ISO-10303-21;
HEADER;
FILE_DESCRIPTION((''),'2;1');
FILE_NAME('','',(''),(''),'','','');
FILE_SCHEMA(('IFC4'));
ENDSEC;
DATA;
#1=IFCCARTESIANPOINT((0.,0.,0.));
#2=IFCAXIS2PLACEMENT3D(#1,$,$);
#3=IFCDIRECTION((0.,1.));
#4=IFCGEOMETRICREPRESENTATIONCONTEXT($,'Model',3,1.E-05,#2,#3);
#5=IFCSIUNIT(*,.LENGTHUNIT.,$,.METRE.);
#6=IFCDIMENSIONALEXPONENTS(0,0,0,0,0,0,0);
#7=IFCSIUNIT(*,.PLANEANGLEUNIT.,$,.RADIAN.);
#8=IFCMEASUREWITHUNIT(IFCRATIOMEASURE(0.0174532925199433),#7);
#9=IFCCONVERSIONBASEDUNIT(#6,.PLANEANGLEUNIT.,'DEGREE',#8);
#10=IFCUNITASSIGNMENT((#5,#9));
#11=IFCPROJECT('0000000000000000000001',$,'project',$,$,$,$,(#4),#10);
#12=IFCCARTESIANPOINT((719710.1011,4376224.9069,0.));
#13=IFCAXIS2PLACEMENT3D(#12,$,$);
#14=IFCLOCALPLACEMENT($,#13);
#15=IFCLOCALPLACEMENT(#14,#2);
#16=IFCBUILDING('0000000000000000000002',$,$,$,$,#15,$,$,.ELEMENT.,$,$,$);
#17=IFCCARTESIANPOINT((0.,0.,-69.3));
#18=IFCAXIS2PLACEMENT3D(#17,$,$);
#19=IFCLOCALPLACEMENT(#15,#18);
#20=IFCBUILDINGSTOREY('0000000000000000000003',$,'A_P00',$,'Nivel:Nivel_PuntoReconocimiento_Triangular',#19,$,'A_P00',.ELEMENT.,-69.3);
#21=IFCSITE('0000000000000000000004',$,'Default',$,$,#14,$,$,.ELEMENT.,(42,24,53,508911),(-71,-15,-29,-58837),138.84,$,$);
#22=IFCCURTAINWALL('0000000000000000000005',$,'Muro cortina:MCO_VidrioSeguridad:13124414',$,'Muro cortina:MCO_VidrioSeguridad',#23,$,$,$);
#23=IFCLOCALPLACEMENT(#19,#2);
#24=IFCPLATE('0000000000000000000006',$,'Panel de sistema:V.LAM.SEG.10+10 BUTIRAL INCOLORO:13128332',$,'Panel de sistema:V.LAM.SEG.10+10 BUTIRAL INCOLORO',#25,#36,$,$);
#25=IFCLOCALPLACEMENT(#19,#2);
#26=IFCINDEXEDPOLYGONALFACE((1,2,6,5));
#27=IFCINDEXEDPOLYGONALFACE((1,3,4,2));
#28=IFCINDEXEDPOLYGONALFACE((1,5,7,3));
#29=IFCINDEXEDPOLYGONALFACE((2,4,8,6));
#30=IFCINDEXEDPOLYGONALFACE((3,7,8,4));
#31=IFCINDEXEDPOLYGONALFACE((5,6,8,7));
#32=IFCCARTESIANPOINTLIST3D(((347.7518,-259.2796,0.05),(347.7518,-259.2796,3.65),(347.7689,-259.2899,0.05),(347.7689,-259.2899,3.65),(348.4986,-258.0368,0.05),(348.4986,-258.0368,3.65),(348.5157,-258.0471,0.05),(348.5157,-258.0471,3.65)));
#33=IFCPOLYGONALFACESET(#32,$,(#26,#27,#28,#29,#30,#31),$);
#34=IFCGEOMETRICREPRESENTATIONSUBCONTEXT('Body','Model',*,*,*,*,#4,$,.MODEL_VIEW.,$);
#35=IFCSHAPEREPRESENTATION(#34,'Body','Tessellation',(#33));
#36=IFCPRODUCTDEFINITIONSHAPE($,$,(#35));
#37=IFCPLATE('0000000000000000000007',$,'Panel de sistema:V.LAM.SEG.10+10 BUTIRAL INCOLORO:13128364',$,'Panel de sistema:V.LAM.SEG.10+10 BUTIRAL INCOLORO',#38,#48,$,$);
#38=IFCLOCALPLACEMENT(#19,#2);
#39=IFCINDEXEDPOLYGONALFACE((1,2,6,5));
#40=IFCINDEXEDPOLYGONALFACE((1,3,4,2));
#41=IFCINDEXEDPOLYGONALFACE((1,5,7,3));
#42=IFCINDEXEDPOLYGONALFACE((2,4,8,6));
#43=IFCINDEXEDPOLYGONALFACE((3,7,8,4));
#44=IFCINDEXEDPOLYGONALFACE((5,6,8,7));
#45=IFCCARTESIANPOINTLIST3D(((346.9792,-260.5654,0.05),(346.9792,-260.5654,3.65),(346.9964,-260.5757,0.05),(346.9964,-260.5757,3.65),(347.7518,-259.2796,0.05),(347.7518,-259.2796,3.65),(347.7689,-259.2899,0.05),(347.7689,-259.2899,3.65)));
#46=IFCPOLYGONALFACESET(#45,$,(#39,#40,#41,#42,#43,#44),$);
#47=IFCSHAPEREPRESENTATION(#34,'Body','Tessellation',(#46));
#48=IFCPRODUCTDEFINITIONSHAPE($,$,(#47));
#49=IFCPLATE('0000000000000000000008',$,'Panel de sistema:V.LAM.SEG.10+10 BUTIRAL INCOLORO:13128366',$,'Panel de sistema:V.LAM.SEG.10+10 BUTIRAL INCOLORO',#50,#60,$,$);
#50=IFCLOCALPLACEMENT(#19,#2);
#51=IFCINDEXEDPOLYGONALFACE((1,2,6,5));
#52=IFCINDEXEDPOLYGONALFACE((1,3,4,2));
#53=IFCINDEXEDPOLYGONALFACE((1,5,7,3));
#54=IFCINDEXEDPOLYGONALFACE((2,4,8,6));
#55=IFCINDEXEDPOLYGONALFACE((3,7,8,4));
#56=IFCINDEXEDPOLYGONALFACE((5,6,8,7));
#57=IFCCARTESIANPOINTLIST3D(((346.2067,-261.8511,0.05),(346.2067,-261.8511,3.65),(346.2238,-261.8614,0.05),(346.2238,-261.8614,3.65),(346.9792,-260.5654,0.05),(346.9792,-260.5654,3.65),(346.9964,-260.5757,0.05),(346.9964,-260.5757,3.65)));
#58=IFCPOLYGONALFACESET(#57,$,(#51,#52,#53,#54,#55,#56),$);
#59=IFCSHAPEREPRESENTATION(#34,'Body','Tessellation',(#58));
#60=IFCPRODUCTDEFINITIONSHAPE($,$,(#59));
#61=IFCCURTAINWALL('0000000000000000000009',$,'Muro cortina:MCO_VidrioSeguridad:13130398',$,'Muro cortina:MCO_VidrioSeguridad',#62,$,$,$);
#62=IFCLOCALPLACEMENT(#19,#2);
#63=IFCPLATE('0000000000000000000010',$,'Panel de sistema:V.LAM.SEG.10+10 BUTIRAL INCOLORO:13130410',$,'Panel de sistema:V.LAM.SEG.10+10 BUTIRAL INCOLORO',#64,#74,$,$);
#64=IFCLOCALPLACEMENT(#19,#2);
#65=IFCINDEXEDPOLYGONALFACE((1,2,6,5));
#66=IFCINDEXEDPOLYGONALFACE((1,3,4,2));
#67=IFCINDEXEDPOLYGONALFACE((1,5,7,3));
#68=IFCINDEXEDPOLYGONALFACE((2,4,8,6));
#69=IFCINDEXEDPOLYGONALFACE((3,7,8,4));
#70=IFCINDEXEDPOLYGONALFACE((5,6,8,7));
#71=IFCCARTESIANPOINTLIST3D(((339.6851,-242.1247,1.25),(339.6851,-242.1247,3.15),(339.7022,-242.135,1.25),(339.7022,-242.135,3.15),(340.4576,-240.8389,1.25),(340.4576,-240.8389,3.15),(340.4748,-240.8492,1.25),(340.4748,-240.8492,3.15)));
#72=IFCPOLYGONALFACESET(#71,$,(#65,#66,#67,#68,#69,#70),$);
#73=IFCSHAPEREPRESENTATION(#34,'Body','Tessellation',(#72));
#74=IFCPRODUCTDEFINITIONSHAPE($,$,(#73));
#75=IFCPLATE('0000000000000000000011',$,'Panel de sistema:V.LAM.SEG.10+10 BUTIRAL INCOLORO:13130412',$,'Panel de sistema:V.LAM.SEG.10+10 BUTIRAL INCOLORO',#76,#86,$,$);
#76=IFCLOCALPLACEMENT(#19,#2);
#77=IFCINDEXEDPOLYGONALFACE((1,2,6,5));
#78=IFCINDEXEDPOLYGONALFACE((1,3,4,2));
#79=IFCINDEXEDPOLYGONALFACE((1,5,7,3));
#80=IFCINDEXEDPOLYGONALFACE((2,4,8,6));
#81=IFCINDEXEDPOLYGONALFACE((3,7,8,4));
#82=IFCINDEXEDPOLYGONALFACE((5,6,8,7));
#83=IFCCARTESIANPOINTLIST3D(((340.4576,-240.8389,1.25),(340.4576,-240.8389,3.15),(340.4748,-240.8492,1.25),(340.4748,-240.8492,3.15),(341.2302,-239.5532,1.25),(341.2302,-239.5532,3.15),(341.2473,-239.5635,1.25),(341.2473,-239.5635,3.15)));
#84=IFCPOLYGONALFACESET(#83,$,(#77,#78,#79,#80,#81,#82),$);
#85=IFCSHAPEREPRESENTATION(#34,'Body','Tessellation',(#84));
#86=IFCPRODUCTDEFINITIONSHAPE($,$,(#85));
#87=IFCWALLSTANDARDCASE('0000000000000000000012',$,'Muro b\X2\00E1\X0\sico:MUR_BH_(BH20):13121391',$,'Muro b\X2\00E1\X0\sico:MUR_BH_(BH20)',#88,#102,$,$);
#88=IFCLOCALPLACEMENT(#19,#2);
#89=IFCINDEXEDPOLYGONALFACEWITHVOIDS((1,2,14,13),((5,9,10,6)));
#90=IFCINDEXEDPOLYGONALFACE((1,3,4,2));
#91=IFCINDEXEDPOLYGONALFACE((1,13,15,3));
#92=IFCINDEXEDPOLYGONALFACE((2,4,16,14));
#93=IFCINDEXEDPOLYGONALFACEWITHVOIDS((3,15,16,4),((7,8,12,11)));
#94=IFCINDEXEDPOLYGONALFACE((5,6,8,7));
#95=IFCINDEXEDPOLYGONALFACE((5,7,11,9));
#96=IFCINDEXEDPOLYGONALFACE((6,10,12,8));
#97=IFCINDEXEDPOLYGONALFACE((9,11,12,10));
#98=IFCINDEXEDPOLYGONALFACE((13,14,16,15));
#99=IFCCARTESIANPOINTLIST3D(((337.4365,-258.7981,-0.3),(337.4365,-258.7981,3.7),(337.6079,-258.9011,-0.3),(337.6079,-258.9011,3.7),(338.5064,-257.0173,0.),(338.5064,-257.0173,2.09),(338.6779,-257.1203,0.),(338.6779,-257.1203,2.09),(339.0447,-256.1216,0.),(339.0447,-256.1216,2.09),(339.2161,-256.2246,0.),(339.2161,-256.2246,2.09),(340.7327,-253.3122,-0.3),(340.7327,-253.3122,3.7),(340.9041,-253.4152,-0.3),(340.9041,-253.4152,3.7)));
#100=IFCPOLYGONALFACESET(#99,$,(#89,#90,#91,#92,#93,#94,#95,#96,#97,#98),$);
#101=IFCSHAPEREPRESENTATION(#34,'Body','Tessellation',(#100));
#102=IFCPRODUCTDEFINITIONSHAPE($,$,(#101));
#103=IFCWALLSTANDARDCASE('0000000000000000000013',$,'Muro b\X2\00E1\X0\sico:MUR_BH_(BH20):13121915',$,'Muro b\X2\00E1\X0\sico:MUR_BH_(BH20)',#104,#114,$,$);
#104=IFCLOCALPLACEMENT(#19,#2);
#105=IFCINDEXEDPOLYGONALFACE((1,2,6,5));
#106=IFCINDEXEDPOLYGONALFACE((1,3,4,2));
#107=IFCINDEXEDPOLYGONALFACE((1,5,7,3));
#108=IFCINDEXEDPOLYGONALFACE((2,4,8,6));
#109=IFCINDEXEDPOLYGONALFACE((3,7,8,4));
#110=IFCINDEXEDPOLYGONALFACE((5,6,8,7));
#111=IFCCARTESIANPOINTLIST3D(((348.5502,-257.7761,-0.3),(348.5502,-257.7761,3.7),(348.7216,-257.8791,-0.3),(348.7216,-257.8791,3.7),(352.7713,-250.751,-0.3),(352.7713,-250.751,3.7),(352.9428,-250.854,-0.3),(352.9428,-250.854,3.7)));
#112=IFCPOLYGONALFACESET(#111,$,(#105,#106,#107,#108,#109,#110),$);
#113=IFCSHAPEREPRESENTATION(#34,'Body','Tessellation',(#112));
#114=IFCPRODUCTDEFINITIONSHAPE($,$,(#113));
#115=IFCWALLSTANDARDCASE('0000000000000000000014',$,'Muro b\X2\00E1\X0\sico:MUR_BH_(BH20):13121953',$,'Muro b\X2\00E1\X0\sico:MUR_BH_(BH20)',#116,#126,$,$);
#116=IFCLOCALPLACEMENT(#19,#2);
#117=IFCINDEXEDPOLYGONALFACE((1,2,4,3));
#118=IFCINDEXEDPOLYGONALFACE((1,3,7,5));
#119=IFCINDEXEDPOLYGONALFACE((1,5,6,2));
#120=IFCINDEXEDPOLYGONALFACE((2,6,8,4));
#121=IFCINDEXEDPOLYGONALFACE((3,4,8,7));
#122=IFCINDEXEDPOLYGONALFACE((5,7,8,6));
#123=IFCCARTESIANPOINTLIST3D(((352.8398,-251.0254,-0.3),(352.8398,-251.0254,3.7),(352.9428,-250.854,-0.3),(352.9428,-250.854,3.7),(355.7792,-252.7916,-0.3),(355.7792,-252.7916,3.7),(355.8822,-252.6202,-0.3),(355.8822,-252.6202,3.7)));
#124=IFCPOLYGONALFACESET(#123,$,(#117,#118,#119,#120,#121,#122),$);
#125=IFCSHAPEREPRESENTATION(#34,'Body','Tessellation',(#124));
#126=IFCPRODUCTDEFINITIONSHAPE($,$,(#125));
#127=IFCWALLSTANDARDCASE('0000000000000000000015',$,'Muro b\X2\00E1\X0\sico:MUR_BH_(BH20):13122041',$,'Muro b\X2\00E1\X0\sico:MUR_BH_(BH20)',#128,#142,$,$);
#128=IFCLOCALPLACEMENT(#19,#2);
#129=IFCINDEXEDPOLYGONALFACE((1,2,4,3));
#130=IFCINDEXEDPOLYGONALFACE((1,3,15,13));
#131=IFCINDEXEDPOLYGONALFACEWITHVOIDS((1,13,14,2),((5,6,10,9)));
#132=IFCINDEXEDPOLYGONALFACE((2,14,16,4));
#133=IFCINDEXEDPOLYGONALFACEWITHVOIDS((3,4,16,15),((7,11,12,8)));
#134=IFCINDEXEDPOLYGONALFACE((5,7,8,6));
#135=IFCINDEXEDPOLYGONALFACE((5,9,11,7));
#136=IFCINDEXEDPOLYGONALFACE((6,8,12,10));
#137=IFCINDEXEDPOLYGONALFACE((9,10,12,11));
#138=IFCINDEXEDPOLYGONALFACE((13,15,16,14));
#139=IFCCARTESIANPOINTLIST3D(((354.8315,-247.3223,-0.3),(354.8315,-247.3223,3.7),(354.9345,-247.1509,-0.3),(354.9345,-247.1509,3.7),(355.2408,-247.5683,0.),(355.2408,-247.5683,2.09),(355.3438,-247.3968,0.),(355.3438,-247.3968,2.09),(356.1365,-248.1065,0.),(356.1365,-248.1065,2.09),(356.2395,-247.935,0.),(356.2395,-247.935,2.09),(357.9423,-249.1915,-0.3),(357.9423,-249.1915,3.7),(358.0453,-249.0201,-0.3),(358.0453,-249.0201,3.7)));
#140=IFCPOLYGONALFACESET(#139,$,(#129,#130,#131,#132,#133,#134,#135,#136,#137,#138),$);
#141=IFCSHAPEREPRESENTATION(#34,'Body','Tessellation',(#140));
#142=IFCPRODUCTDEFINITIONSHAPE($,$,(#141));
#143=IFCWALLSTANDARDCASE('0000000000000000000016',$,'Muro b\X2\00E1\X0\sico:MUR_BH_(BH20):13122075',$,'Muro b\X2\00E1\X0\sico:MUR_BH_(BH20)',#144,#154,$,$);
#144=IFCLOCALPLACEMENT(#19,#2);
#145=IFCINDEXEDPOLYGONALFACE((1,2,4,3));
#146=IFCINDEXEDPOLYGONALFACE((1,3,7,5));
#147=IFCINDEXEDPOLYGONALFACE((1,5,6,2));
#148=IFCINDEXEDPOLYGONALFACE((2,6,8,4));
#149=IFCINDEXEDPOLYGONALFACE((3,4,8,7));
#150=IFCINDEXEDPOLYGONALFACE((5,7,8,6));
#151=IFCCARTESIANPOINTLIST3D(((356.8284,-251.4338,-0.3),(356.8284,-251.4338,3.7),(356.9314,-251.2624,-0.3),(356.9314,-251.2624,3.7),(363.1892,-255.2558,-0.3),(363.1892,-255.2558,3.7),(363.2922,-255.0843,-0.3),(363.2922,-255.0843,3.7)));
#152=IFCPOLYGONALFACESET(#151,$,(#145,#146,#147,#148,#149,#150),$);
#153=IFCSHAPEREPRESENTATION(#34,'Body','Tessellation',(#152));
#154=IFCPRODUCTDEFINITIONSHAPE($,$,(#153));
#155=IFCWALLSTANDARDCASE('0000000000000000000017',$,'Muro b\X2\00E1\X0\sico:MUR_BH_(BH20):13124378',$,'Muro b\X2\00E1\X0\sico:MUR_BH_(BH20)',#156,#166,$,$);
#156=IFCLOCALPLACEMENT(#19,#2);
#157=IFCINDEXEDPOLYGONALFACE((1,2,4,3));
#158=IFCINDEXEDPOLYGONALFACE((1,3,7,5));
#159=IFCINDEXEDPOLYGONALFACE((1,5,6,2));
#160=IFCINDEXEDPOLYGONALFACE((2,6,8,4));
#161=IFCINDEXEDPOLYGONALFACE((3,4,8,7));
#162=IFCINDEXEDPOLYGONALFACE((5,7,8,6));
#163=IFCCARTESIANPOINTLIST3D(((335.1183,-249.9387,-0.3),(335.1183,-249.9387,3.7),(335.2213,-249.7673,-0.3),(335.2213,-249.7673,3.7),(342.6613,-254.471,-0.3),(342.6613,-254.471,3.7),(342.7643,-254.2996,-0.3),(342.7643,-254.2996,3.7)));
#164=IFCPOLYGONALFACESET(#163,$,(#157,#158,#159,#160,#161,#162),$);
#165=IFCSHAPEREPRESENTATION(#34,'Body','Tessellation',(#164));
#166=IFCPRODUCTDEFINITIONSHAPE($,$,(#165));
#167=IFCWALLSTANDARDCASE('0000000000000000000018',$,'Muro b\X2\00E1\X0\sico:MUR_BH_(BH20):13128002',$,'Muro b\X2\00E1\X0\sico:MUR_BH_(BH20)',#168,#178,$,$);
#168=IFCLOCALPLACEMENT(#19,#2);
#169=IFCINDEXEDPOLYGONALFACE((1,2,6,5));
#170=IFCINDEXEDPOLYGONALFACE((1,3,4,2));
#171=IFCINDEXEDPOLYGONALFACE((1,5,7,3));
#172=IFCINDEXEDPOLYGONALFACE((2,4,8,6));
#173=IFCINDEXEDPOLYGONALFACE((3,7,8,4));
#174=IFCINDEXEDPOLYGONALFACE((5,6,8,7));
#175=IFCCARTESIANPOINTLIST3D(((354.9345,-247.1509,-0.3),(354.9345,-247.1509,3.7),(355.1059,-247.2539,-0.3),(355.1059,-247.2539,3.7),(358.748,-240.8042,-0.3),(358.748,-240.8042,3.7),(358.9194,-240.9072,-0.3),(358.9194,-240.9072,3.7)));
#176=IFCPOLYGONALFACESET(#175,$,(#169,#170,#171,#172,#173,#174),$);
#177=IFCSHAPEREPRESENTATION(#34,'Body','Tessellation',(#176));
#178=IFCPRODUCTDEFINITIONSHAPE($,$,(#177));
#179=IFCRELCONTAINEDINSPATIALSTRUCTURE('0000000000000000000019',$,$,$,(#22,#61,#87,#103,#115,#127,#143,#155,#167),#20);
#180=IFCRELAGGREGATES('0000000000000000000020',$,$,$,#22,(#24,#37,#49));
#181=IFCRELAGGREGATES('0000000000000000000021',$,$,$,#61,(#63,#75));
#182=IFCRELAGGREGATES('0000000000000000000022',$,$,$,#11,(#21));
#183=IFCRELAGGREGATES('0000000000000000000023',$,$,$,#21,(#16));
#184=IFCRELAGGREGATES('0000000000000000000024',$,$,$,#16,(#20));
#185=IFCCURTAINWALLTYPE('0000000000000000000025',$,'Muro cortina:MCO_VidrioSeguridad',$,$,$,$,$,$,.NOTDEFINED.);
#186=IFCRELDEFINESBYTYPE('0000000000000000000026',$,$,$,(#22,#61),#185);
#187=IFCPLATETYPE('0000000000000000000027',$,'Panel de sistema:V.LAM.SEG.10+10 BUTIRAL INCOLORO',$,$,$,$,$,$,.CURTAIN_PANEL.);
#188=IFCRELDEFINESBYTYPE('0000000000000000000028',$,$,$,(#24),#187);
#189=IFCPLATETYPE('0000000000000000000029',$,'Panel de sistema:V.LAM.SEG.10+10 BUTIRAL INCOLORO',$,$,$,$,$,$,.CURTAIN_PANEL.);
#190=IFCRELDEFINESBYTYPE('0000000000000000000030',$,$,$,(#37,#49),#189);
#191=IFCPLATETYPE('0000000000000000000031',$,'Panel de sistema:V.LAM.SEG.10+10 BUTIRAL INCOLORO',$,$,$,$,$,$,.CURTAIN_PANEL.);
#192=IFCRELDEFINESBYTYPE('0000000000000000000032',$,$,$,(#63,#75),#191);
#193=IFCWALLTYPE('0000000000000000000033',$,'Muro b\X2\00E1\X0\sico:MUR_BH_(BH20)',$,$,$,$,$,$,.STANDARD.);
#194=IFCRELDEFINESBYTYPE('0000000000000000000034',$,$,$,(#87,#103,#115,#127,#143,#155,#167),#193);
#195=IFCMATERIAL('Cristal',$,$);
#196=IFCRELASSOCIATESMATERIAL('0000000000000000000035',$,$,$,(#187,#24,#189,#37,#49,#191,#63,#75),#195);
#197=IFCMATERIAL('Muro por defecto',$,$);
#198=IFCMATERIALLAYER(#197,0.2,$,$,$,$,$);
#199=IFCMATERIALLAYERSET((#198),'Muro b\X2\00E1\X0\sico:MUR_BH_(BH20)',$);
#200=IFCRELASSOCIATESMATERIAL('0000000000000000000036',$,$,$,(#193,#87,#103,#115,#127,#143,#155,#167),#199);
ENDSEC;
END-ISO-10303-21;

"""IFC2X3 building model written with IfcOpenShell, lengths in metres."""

from ifc_helpers import new_model, entity, si_unit, converted_unit, direction, frame, frame_2d, origin, origin_2d_with_axis, place, context, subcontext, project, spatial, rectangle, extrude, source, transform, mapped, material, layer, layer_set, layer_usage, type_object, type_shapes, element, aggregate, save


model = new_model("IFC2X3")

# Units and contexts
model_context = context("Model", 3, precision=1e-05, world=origin(), true_north=direction((0.0, 1.0)))
body_context = subcontext(model_context, "Body", "Model", "MODEL_VIEW")
ifc_project = project(units=[si_unit("LENGTHUNIT", "METRE"), converted_unit("PLANEANGLEUNIT", "DEGREE", entity("IfcRatioMeasure", 0.0174532925199433), si_unit("PLANEANGLEUNIT", "RADIAN"), dimensions=[0, 0, 0, 0, 0, 0, 0])], contexts=[model_context])

# Site, building, storey
site_placement = place(None, frame((719710.1011, 4376224.9069, 0.0)))
site = spatial("IfcSite", under=ifc_project, at=site_placement, Name="Default", CompositionType="ELEMENT", RefLatitude=(42, 24, 53, 508911), RefLongitude=(-71, -15, -29, -58837), RefElevation=138.84)
building_placement = place(site_placement, origin())
building = spatial("IfcBuilding", under=site, at=building_placement, CompositionType="ELEMENT")
storey_placement = place(building_placement, frame((0.0, 0.0, -69.3)))
storey = spatial("IfcBuildingStorey", under=building, at=storey_placement, Name="A_P00", ObjectType="Nivel:Nivel_PuntoReconocimiento_Triangular", LongName="A_P00", CompositionType="ELEMENT", Elevation=-69.3)

# Curtain walls, plates
curtain_wall_type = type_object("IfcCurtainWallType", Name="Muro cortina:MCO_VidrioSeguridad", PredefinedType="NOTDEFINED")
curtain_wall_1_placement = place(storey_placement, frame((0.0, 0.0, 69.3)))
curtain_wall_1 = element("IfcCurtainWall", 1, at=curtain_wall_1_placement, inside=storey, type_object=curtain_wall_type, Name="Muro cortina:MCO_VidrioSeguridad:13124414", ObjectType="Muro cortina:MCO_VidrioSeguridad")
ifc_material_1 = material(Name="Cristal")
plate_type_1 = type_object("IfcPlateType", Name="Panel de sistema:V.LAM.SEG.10+10 BUTIRAL INCOLORO", PredefinedType="CURTAIN_PANEL", material=ifc_material_1)
shared_shape_1 = source(origin(), body_context, "Body", "SweptSolid", [
    extrude(rectangle(XDim=0.02, YDim=1.45, at=frame_2d((0.0, 0.0), x_axis=(1.0, 0.0))), frame((0.0, 0.0, 0.0), z_axis=(0.0, 0.0, 1.0), x_axis=(0.0, 1.0, 0.0)), (0.0, 0.0, 1.0), 3.6),
])
type_shapes(plate_type_1, [shared_shape_1])
plate_1_placement = place(curtain_wall_1_placement, frame((348.1338, -258.6634, -69.25), z_axis=(0.0, 0.0, 1.0), x_axis=(-0.515038, -0.857167, 0.0)))
plate_1 = element("IfcPlate", 2, at=plate_1_placement, type_object=plate_type_1, material=ifc_material_1, Name="Panel de sistema:V.LAM.SEG.10+10 BUTIRAL INCOLORO:13128332", ObjectType="Panel de sistema:V.LAM.SEG.10+10 BUTIRAL INCOLORO", context=body_context, shape_type="MappedRepresentation", body=[
    mapped(shared_shape_1, transform((0.0, 0.0, 0.0), scale=1.0)),
])
plate_type_2 = type_object("IfcPlateType", Name="Panel de sistema:V.LAM.SEG.10+10 BUTIRAL INCOLORO", PredefinedType="CURTAIN_PANEL", material=ifc_material_1)
shared_shape_2 = source(origin(), body_context, "Body", "SweptSolid", [
    extrude(rectangle(XDim=0.02, YDim=1.5, at=frame_2d((0.0, 0.0), x_axis=(1.0, 0.0))), frame((0.0, 0.0, 0.0), z_axis=(0.0, 0.0, 1.0), x_axis=(0.0, 1.0, 0.0)), (0.0, 0.0, 1.0), 3.6),
])
type_shapes(plate_type_2, [shared_shape_2])
plate_2_placement = place(curtain_wall_1_placement, frame((347.3741, -259.9277, -69.25), z_axis=(0.0, 0.0, 1.0), x_axis=(-0.515038, -0.857167, 0.0)))
plate_2 = element("IfcPlate", 3, at=plate_2_placement, type_object=plate_type_2, material=ifc_material_1, Name="Panel de sistema:V.LAM.SEG.10+10 BUTIRAL INCOLORO:13128364", ObjectType="Panel de sistema:V.LAM.SEG.10+10 BUTIRAL INCOLORO", context=body_context, shape_type="MappedRepresentation", body=[
    mapped(shared_shape_2, transform((0.0, 0.0, 0.0), scale=1.0)),
])
plate_3_placement = place(curtain_wall_1_placement, frame((346.6015, -261.2134, -69.25), z_axis=(0.0, 0.0, 1.0), x_axis=(-0.515038, -0.857167, 0.0)))
plate_3 = element("IfcPlate", 4, at=plate_3_placement, type_object=plate_type_2, material=ifc_material_1, Name="Panel de sistema:V.LAM.SEG.10+10 BUTIRAL INCOLORO:13128366", ObjectType="Panel de sistema:V.LAM.SEG.10+10 BUTIRAL INCOLORO", context=body_context, shape_type="MappedRepresentation", body=[
    mapped(shared_shape_2, transform((0.0, 0.0, 0.0), scale=1.0)),
])
aggregate(curtain_wall_1, [plate_1, plate_2, plate_3])
curtain_wall_2_placement = place(storey_placement, frame((0.0, 0.0, 69.3)))
curtain_wall_2 = element("IfcCurtainWall", 5, at=curtain_wall_2_placement, inside=storey, type_object=curtain_wall_type, Name="Muro cortina:MCO_VidrioSeguridad:13130398", ObjectType="Muro cortina:MCO_VidrioSeguridad")
plate_type_3 = type_object("IfcPlateType", Name="Panel de sistema:V.LAM.SEG.10+10 BUTIRAL INCOLORO", PredefinedType="CURTAIN_PANEL", material=ifc_material_1)
shared_shape_3 = source(origin(), body_context, "Body", "SweptSolid", [
    extrude(rectangle(XDim=0.02, YDim=1.5, at=origin_2d_with_axis()), frame((0.0, 0.0, 0.0), z_axis=(0.0, 0.0, 1.0), x_axis=(0.0, 1.0, 0.0)), (0.0, 0.0, 1.0), 1.9),
])
type_shapes(plate_type_3, [shared_shape_3])
plate_4_placement = place(curtain_wall_2_placement, frame((340.0799, -241.487, -68.05), z_axis=(0.0, 0.0, 1.0), x_axis=(0.515038, 0.857167, 0.0)))
plate_4 = element("IfcPlate", 6, at=plate_4_placement, type_object=plate_type_3, material=ifc_material_1, Name="Panel de sistema:V.LAM.SEG.10+10 BUTIRAL INCOLORO:13130410", ObjectType="Panel de sistema:V.LAM.SEG.10+10 BUTIRAL INCOLORO", context=body_context, shape_type="MappedRepresentation", body=[
    mapped(shared_shape_3, transform((0.0, 0.0, 0.0), scale=1.0)),
])
plate_5_placement = place(curtain_wall_2_placement, frame((340.8525, -240.2012, -68.05), z_axis=(0.0, 0.0, 1.0), x_axis=(0.515038, 0.857167, 0.0)))
plate_5 = element("IfcPlate", 7, at=plate_5_placement, type_object=plate_type_3, material=ifc_material_1, Name="Panel de sistema:V.LAM.SEG.10+10 BUTIRAL INCOLORO:13130412", ObjectType="Panel de sistema:V.LAM.SEG.10+10 BUTIRAL INCOLORO", context=body_context, shape_type="MappedRepresentation", body=[
    mapped(shared_shape_3, transform((0.0, 0.0, 0.0), scale=1.0)),
])
aggregate(curtain_wall_2, [plate_4, plate_5])

# Wall, opening
ifc_material_2 = material(Name="Muro por defecto")
ifc_layer = layer(ifc_material_2, 0.2)
ifc_layer_set = layer_set([ifc_layer], Name="Muro básico:MUR_BH_(BH20)")
ifc_layer_usage_1 = layer_usage(ifc_layer_set, "AXIS2", "NEGATIVE", 0.1)
wall_type = type_object("IfcWallType", Name="Muro básico:MUR_BH_(BH20)", PredefinedType="STANDARD", material=ifc_layer_set)
wall_1_placement = place(storey_placement, frame((340.8184, -253.3637, -0.3), z_axis=(0.0, 0.0, 1.0), x_axis=(-0.515038, -0.857167, 0.0)))
wall_1 = element("IfcWallStandardCase", 8, at=wall_1_placement, inside=storey, type_object=wall_type, material=ifc_layer_usage_1, Name="Muro básico:MUR_BH_(BH20):13121391", ObjectType="Muro básico:MUR_BH_(BH20)", context=body_context, shape_type="SweptSolid", body=[
    extrude(rectangle(XDim=6.4, YDim=0.2, at=frame_2d((3.2, 0.0), x_axis=(-1.0, 0.0))), origin(), (0.0, 0.0, 1.0), 4.0),
])
opening_1_placement = place(wall_1_placement, frame((-41.6406, -422.6304, 0.3), z_axis=(0.0, 0.0, 1.0), x_axis=(-0.515038, 0.857167, 0.0)))
element("IfcOpeningElement", 9, at=opening_1_placement, cuts=wall_1, ObjectType="Opening", context=body_context, shape_type="SweptSolid", body=[
    extrude(rectangle(XDim=2.09, YDim=1.045, at=frame_2d((0.0, 0.0), x_axis=(1.0, 0.0))), frame((338.7756, -256.5694, 1.045), z_axis=(0.857167, -0.515038, 0.0), x_axis=(0.0, 0.0, -1.0)), (0.0, 0.0, 1.0), 0.2),
])

# Wall
ifc_layer_usage_2 = layer_usage(ifc_layer_set, "AXIS2", "NEGATIVE", 0.1)
wall_2_placement = place(storey_placement, frame((348.6359, -257.8276, -0.3), z_axis=(0.0, 0.0, 1.0), x_axis=(0.515038, 0.857167, 0.0)))
element("IfcWallStandardCase", 10, at=wall_2_placement, inside=storey, type_object=wall_type, material=ifc_layer_usage_2, Name="Muro básico:MUR_BH_(BH20):13121915", ObjectType="Muro básico:MUR_BH_(BH20)", context=body_context, shape_type="SweptSolid", body=[
    extrude(rectangle(XDim=8.1957, YDim=0.2, at=frame_2d((4.0979, 0.0), x_axis=(-1.0, 0.0))), origin(), (0.0, 0.0, 1.0), 4.0),
])

# Wall
ifc_layer_usage_3 = layer_usage(ifc_layer_set, "AXIS2", "NEGATIVE", 0.1)
wall_3_placement = place(storey_placement, frame((352.8913, -250.9397, -0.3), z_axis=(0.0, 0.0, 1.0), x_axis=(0.857167, -0.515038, 0.0)))
element("IfcWallStandardCase", 11, at=wall_3_placement, inside=storey, type_object=wall_type, material=ifc_layer_usage_3, Name="Muro básico:MUR_BH_(BH20):13121953", ObjectType="Muro básico:MUR_BH_(BH20)", context=body_context, shape_type="SweptSolid", body=[
    extrude(rectangle(XDim=3.4292, YDim=0.2, at=frame_2d((1.7146, 0.0), x_axis=(-1.0, 0.0))), origin(), (0.0, 0.0, 1.0), 4.0),
])

# Wall, opening
ifc_layer_usage_4 = layer_usage(ifc_layer_set, "AXIS2", "NEGATIVE", 0.1)
wall_4_placement = place(storey_placement, frame((354.883, -247.2366, -0.3), z_axis=(0.0, 0.0, 1.0), x_axis=(0.857167, -0.515038, 0.0)))
wall_4 = element("IfcWallStandardCase", 12, at=wall_4_placement, inside=storey, type_object=wall_type, material=ifc_layer_usage_4, Name="Muro básico:MUR_BH_(BH20):13122041", ObjectType="Muro básico:MUR_BH_(BH20)", context=body_context, shape_type="SweptSolid", body=[
    extrude(rectangle(XDim=3.6292, YDim=0.2, at=frame_2d((1.8146, 0.0), x_axis=(-1.0, 0.0))), origin(), (0.0, 0.0, 1.0), 4.0),
])
opening_2_placement = place(wall_4_placement, frame((-431.5304, 29.1449, 0.3), z_axis=(0.0, 0.0, 1.0), x_axis=(0.857167, 0.515038, 0.0)))
element("IfcOpeningElement", 13, at=opening_2_placement, cuts=wall_4, ObjectType="Opening", context=body_context, shape_type="SweptSolid", body=[
    extrude(rectangle(XDim=2.09, YDim=1.045, at=frame_2d((0.0, 0.0), x_axis=(0.0, 1.0))), frame((355.6887, -247.8374, 1.045), z_axis=(0.515038, 0.857167, 0.0), x_axis=(0.857167, -0.515038, 0.0)), (0.0, 0.0, 1.0), 0.2),
])

# Walls
ifc_layer_usage_5 = layer_usage(ifc_layer_set, "AXIS2", "NEGATIVE", 0.1)
wall_5_placement = place(storey_placement, frame((356.8799, -251.3481, -0.3), z_axis=(0.0, 0.0, 1.0), x_axis=(0.857167, -0.515038, 0.0)))
element("IfcWallStandardCase", 14, at=wall_5_placement, inside=storey, type_object=wall_type, material=ifc_layer_usage_5, Name="Muro básico:MUR_BH_(BH20):13122075", ObjectType="Muro básico:MUR_BH_(BH20)", context=body_context, shape_type="SweptSolid", body=[
    extrude(rectangle(XDim=7.4208, YDim=0.2, at=frame_2d((3.7104, 0.0), x_axis=(-1.0, 0.0))), origin(), (0.0, 0.0, 1.0), 4.0),
])
ifc_layer_usage_6 = layer_usage(ifc_layer_set, "AXIS2", "NEGATIVE", 0.1)
wall_6_placement = place(storey_placement, frame((342.7128, -254.3853, -0.3), z_axis=(0.0, 0.0, 1.0), x_axis=(-0.857167, 0.515038, 0.0)))
element("IfcWallStandardCase", 15, at=wall_6_placement, inside=storey, type_object=wall_type, material=ifc_layer_usage_6, Name="Muro básico:MUR_BH_(BH20):13124378", ObjectType="Muro básico:MUR_BH_(BH20)", context=body_context, shape_type="SweptSolid", body=[
    extrude(rectangle(XDim=8.8, YDim=0.2, at=frame_2d((4.4, 0.0), x_axis=(-1.0, 0.0))), origin(), (0.0, 0.0, 1.0), 4.0),
])
ifc_layer_usage_7 = layer_usage(ifc_layer_set, "AXIS2", "NEGATIVE", 0.1)
wall_7_placement = place(storey_placement, frame((355.0202, -247.2024, -0.3), z_axis=(0.0, 0.0, 1.0), x_axis=(0.515038, 0.857167, 0.0)))
element("IfcWallStandardCase", 16, at=wall_7_placement, inside=storey, type_object=wall_type, material=ifc_layer_usage_7, Name="Muro básico:MUR_BH_(BH20):13128002", ObjectType="Muro básico:MUR_BH_(BH20)", context=body_context, shape_type="SweptSolid", body=[
    extrude(rectangle(XDim=7.4043, YDim=0.2, at=frame_2d((3.7021, 0.0), x_axis=(-1.0, 0.0))), origin(), (0.0, 0.0, 1.0), 4.0),
])

save(model, "model.ifc")
